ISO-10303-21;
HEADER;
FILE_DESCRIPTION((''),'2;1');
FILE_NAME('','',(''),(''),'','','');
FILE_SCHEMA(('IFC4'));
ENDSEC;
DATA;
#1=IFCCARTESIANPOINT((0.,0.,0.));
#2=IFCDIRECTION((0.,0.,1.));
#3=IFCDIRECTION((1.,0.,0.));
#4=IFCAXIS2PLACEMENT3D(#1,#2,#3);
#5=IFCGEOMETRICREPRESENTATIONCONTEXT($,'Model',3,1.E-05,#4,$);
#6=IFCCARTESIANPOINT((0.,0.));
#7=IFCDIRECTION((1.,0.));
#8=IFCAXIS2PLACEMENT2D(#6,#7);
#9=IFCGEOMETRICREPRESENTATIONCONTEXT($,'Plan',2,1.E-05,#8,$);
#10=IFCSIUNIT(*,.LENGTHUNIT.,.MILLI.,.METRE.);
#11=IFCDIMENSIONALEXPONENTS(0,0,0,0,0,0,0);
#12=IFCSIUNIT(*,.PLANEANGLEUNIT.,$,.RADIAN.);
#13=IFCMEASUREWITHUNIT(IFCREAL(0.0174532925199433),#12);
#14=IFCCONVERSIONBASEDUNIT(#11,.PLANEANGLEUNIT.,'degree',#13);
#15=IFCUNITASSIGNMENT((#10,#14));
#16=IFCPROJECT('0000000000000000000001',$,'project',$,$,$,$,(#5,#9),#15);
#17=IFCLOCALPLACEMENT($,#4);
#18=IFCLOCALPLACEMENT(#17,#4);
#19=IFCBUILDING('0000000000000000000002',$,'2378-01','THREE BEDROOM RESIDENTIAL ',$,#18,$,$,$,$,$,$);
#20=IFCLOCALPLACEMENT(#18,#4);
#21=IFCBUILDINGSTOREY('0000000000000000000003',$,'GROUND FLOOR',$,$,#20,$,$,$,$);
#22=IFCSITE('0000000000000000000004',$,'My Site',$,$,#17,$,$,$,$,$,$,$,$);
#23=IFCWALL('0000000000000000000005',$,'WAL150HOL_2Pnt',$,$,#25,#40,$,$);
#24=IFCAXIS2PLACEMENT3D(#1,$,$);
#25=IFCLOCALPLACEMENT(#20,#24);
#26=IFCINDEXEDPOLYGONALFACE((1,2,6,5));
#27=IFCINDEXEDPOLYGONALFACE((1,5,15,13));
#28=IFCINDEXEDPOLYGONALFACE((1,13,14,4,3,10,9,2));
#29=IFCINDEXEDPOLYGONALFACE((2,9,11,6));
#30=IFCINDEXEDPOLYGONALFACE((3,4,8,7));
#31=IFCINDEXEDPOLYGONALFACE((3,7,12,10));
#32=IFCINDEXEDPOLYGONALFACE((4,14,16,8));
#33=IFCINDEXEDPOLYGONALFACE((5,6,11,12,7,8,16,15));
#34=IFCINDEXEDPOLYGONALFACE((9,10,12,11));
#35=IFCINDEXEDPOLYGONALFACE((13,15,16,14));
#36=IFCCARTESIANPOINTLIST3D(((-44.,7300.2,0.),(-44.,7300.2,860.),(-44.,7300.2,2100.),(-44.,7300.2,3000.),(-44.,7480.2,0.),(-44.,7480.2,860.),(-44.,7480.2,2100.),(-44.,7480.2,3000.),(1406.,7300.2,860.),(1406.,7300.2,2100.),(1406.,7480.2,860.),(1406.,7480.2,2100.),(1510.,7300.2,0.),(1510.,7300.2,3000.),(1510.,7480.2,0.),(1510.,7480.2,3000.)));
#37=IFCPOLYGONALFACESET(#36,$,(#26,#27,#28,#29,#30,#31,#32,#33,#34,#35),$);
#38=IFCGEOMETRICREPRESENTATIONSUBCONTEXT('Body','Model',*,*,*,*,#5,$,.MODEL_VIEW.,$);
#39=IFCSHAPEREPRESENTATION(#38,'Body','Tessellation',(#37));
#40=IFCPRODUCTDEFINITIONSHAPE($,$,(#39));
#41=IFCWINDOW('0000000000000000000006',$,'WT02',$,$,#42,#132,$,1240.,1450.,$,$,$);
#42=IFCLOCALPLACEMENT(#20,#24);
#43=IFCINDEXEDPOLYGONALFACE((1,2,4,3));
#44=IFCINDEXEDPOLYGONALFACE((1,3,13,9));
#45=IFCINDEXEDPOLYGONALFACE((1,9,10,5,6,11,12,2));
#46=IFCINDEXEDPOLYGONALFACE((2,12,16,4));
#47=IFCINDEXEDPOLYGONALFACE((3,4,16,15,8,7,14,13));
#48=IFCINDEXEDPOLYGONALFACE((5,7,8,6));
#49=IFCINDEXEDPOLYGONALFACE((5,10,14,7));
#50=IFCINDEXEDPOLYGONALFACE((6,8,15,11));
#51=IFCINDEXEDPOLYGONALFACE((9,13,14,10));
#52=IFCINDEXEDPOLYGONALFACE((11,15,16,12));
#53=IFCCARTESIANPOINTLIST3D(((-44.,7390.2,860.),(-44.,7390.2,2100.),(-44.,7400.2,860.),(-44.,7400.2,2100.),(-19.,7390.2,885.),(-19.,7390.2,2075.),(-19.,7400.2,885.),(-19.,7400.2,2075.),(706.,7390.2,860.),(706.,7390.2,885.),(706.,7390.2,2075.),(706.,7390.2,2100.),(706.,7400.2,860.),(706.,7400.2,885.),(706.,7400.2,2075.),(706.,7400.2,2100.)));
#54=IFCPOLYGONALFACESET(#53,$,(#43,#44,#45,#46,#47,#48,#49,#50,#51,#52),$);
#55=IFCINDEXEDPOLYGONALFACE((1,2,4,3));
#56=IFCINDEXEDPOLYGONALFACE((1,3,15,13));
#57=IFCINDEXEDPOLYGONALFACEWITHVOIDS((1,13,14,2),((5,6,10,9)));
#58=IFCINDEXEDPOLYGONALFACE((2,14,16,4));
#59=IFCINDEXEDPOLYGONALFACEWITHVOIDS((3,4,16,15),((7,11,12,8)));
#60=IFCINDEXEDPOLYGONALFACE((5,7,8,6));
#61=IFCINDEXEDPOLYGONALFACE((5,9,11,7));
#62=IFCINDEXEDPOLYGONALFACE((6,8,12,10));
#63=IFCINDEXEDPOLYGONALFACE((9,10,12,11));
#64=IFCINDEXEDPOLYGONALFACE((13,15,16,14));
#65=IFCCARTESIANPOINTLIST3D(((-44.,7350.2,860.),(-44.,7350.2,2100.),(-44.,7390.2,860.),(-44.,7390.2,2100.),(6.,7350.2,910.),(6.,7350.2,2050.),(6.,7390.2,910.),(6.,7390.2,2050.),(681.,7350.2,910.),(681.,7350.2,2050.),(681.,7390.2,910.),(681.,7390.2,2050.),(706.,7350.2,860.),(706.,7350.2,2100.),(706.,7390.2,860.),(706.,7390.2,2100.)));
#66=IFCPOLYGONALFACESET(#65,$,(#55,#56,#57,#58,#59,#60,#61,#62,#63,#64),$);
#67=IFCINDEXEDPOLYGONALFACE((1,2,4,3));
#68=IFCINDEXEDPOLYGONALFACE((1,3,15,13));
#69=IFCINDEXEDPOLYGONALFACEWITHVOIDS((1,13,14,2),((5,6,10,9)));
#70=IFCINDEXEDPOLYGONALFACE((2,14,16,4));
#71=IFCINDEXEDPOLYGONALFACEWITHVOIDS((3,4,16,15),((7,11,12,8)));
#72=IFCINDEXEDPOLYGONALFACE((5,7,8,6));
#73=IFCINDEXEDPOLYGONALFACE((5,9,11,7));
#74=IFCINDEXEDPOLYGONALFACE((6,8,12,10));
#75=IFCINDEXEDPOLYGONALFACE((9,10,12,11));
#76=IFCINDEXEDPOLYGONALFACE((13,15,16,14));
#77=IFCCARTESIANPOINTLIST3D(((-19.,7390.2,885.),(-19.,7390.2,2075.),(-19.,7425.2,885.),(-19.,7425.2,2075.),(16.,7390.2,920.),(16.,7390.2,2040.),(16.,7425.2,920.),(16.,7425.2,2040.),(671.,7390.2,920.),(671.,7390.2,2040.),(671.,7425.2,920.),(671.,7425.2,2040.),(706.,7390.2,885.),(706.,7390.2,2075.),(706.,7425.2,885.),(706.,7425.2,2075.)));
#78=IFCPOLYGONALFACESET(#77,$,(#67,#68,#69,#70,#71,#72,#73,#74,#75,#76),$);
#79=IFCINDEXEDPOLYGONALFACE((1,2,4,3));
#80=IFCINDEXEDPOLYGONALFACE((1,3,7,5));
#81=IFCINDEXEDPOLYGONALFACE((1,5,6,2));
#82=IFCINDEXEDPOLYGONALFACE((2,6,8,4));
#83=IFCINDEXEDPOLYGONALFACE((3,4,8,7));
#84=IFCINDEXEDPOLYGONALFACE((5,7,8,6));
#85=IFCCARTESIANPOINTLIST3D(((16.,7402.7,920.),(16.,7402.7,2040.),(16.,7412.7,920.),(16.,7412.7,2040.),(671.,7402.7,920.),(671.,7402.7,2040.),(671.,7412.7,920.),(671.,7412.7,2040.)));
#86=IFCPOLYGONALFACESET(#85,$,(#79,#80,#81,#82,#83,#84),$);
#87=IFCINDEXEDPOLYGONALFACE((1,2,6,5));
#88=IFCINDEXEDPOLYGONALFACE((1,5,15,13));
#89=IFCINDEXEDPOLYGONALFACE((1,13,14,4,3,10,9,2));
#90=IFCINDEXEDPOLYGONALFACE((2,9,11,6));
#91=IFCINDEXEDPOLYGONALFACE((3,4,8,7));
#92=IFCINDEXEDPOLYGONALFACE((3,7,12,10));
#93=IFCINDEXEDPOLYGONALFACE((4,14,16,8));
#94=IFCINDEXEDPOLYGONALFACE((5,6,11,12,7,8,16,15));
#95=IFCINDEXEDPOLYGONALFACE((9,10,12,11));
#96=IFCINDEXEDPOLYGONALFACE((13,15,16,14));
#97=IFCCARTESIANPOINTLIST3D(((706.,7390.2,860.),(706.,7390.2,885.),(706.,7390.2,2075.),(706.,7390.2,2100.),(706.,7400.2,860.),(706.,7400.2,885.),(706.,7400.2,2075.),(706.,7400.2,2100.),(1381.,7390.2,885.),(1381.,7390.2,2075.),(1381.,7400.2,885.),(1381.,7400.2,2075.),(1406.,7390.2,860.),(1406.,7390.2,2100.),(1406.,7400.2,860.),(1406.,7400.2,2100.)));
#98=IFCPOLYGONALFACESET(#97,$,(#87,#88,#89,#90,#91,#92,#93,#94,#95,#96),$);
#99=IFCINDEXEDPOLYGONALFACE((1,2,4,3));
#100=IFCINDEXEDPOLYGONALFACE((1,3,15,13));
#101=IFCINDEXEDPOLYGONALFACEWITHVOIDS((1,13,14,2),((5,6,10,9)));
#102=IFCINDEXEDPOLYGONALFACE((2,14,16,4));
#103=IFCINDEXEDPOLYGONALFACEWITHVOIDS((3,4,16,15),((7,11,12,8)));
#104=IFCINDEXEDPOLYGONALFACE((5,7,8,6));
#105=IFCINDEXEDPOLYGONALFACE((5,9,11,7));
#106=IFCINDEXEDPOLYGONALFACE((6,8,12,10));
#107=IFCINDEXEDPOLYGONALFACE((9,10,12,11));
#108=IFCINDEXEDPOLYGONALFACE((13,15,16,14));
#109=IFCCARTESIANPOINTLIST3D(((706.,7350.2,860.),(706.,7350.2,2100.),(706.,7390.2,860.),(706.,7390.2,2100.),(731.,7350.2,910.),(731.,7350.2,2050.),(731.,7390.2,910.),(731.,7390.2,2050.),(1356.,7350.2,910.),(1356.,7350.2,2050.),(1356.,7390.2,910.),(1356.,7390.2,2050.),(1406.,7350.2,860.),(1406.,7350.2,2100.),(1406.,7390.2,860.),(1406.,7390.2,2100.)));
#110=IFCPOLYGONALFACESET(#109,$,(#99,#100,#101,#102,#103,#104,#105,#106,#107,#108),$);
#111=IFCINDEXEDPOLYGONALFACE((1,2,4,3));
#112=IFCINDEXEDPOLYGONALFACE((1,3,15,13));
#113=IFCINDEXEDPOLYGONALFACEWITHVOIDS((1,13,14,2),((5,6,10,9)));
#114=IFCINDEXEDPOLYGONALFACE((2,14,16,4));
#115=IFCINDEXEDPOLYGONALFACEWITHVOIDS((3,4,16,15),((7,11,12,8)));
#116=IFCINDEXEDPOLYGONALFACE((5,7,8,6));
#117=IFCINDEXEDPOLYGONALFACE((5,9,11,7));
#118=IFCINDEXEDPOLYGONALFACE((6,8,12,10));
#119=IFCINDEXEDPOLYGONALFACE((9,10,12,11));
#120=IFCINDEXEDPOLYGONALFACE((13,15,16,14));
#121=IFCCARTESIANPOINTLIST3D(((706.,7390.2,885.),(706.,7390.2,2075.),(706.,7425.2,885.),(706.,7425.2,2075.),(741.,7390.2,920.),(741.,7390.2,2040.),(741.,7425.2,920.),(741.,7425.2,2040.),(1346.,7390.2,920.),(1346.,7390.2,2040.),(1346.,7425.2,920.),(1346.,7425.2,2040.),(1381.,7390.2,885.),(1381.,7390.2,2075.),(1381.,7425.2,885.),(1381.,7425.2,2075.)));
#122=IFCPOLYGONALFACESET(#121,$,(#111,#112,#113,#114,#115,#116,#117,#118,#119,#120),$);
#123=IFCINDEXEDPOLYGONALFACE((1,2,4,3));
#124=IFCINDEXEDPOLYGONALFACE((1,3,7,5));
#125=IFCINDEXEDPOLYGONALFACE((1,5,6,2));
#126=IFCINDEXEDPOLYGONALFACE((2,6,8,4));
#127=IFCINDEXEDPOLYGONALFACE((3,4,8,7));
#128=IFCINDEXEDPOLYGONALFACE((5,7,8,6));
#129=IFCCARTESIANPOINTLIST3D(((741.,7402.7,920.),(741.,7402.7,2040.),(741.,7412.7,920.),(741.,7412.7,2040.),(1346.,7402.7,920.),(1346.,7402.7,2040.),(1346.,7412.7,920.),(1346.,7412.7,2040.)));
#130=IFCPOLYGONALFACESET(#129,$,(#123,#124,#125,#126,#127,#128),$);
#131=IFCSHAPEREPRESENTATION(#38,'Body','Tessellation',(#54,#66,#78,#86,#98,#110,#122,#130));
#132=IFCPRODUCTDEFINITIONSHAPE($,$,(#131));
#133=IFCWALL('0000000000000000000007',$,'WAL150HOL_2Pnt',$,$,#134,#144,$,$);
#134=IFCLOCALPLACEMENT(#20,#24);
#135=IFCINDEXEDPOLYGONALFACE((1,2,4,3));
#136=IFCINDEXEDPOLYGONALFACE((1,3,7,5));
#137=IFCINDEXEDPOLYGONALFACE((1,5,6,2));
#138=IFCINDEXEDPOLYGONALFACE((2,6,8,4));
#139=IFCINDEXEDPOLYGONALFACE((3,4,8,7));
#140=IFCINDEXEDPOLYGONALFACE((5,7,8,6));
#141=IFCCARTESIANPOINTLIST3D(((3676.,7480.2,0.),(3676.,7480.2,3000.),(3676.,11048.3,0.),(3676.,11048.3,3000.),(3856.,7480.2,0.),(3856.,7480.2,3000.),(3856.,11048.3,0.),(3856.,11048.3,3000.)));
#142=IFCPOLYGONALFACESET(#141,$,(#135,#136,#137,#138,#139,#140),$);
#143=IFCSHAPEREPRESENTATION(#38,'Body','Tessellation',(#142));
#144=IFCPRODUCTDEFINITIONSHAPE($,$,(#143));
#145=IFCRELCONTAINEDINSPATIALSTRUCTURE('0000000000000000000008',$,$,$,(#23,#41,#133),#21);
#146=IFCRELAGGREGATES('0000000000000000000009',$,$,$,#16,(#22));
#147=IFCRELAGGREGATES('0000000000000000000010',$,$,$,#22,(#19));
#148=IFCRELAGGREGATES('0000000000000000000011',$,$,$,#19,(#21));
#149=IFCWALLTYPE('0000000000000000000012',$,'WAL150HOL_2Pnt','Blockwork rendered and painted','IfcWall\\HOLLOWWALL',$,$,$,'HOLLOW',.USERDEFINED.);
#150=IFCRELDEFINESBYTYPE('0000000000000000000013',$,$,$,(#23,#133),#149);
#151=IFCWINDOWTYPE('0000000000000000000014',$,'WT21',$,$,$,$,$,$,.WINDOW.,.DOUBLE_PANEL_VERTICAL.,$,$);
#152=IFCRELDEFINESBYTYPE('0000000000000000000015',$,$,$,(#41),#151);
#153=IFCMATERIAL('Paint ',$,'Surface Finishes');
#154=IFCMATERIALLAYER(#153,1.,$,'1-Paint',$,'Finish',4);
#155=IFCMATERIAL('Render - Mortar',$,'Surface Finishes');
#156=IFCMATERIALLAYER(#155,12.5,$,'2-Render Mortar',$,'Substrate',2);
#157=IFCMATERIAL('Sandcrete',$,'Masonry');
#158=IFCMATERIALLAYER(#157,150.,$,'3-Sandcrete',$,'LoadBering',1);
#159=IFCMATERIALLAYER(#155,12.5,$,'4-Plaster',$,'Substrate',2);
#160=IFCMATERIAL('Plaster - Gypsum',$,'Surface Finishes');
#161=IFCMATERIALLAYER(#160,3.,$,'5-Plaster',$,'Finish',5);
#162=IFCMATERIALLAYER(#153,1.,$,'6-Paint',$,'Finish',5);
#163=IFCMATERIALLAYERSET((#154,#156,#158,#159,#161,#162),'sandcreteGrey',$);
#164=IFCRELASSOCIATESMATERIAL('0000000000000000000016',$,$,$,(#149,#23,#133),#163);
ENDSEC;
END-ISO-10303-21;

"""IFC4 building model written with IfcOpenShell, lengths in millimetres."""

from ifc_helpers import new_model, entity, si_unit, converted_unit, frame, origin_with_axes, origin_2d_with_axis, place, context, subcontext, project, spatial, line, indexed_curve, outline, extrude, shape, source, transform, mapped, material, layer, layer_set, layer_usage, type_object, type_shapes, element, fill, save


model = new_model("IFC4")

# Units and contexts
model_context = context("Model", 3, precision=1e-05, world=origin_with_axes())
plan_context = context("Plan", 2, precision=1e-05, world=origin_2d_with_axis())
body_context_1 = subcontext(model_context, "Body", "Model", "MODEL_VIEW")
body_context_2 = subcontext(plan_context, "Body", "Plan", "PLAN_VIEW")
ifc_project = project(units=[si_unit("LENGTHUNIT", "METRE", prefix="MILLI"), converted_unit("PLANEANGLEUNIT", "degree", entity("IfcReal", 0.0174532925199433), si_unit("PLANEANGLEUNIT", "RADIAN"), dimensions=[0, 0, 0, 0, 0, 0, 0])], contexts=[model_context, plan_context])

# Site, building, storey
site_placement = place(None, origin_with_axes())
site = spatial("IfcSite", under=ifc_project, at=site_placement, Name="My Site")
building_placement = place(site_placement, origin_with_axes())
building = spatial("IfcBuilding", under=site, at=building_placement, Name="2378-01", Description="THREE BEDROOM RESIDENTIAL ")
storey_placement = place(building_placement, origin_with_axes())
storey = spatial("IfcBuildingStorey", under=building, at=storey_placement, Name="GROUND FLOOR")

# Wall, opening, window
ifc_material_1 = material(Name="Paint ", Category="Surface Finishes")
ifc_layer_1 = layer(ifc_material_1, 1.0, Name="1-Paint", Category="Finish", Priority=4)
ifc_material_2 = material(Name="Render - Mortar", Category="Surface Finishes")
ifc_layer_2 = layer(ifc_material_2, 12.5, Name="2-Render Mortar", Category="Substrate", Priority=2)
ifc_material_3 = material(Name="Sandcrete", Category="Masonry")
ifc_layer_3 = layer(ifc_material_3, 150.0, Name="3-Sandcrete", Category="LoadBering", Priority=1)
ifc_layer_4 = layer(ifc_material_2, 12.5, Name="4-Plaster", Category="Substrate", Priority=2)
ifc_material_4 = material(Name="Plaster - Gypsum", Category="Surface Finishes")
ifc_layer_5 = layer(ifc_material_4, 3.0, Name="5-Plaster", Category="Finish", Priority=5)
ifc_layer_6 = layer(ifc_material_1, 1.0, Name="6-Paint", Category="Finish", Priority=5)
ifc_layer_set_1 = layer_set([ifc_layer_1, ifc_layer_2, ifc_layer_3, ifc_layer_4, ifc_layer_5, ifc_layer_6], Name="sandcreteGrey")
ifc_layer_usage_1 = layer_usage(ifc_layer_set_1, "AXIS2", "POSITIVE", 0.0)
wall_type_1 = type_object("IfcWallType", Name="WAL150HOL_2Pnt", Description="Blockwork rendered and painted", ApplicableOccurrence="IfcWall\\HOLLOWWALL", ElementType="HOLLOW", PredefinedType="USERDEFINED", material=ifc_layer_set_1)
wall_1_placement = place(storey_placement, frame((-44.0, 7300.2, 0.0), z_axis=(0.0, 0.0, 1.0), x_axis=(1.0, 0.0, 0.0)))
wall_1 = element("IfcWall", 1, at=wall_1_placement, inside=storey, type_object=wall_type_1, material=ifc_layer_usage_1, Name="WAL150HOL_2Pnt", context=body_context_1, shape_type="SweptSolid", body=[
    extrude(outline(indexed_curve([(0.0, 0.0), (0.0, 180.0), (1554.0, 180.0), (1554.0, 0.0), (0.0, 0.0)], self_intersect=False)), origin_with_axes(), (0.0, 0.0, 1.0), 3000.0),
])
shared_shape_1 = source(origin_with_axes(), body_context_1, "Body", "SweptSolid", [
    extrude(outline(indexed_curve([(0.0, 0.0), (1450.0, 0.0), (1450.0, 1240.0), (0.0, 1240.0)], segments=[line(1, 2, 3, 4, 1)])), frame((0.0, -100.0, 0.0), z_axis=(0.0, -1.0, 0.0), x_axis=(1.0, 0.0, 0.0)), (0.0, 0.0, -1.0), 388.0),
])
opening_1_placement = place(wall_1_placement, frame((0.0, 0.0, 860.0), z_axis=(0.0, 0.0, 1.0), x_axis=(1.0, 0.0, 0.0)))
opening_1 = element("IfcOpeningElement", 2, at=opening_1_placement, cuts=wall_1, PredefinedType="OPENING", context=body_context_1, shape_type="MappedRepresentation", body=[
    mapped(shared_shape_1, transform((0.0, 0.0, 0.0), x_axis=(1.0, 0.0, 0.0), y_axis=(0.0, 1.0, 0.0), z_axis=(0.0, 0.0, 1.0), scale=1.0)),
])
window_type_1 = type_object("IfcWindowType", Name="WT21", PartitioningType="DOUBLE_PANEL_VERTICAL", PredefinedType="WINDOW")
shared_shape_2 = source(origin_with_axes(), body_context_1, "Body", "SweptSolid", [
    extrude(outline(indexed_curve([(750.0, 0.0), (0.0, 0.0), (0.0, 1240.0), (750.0, 1240.0), (750.0, 1215.0), (25.0, 1215.0), (25.0, 25.0), (750.0, 25.0)], segments=[line(1, 2, 3, 4, 5, 6, 7, 8, 1)])), frame((0.0, 90.0, 0.0), z_axis=(0.0, -1.0, 0.0), x_axis=(1.0, 0.0, 0.0)), (0.0, 0.0, -1.0), 10.0),
    extrude(outline(indexed_curve([(0.0, 0.0), (750.0, 0.0), (750.0, 1240.0), (0.0, 1240.0)], segments=[line(1, 2, 3, 4, 1)]), holes=[indexed_curve([(50.0, 50.0), (725.0, 50.0), (725.0, 1190.0), (50.0, 1190.0)], segments=[line(1, 2, 3, 4, 1)])]), frame((0.0, 50.0, 0.0), z_axis=(0.0, -1.0, 0.0), x_axis=(1.0, 0.0, 0.0)), (0.0, 0.0, -1.0), 40.0),
    extrude(outline(indexed_curve([(0.0, 0.0), (725.0, 0.0), (725.0, 1190.0), (0.0, 1190.0)], segments=[line(1, 2, 3, 4, 1)]), holes=[indexed_curve([(35.0, 35.0), (690.0, 35.0), (690.0, 1155.0), (35.0, 1155.0)], segments=[line(1, 2, 3, 4, 1)])]), frame((25.0, 90.0, 25.0), z_axis=(0.0, -1.0, 0.0), x_axis=(1.0, 0.0, 0.0)), (0.0, 0.0, -1.0), 35.0),
    extrude(outline(indexed_curve([(35.0, 35.0), (690.0, 35.0), (690.0, 1155.0), (35.0, 1155.0)], segments=[line(1, 2, 3, 4, 1)])), frame((25.0, 102.5, 25.0), z_axis=(0.0, -1.0, 0.0), x_axis=(1.0, 0.0, 0.0)), (0.0, 0.0, -1.0), 10.0),
    extrude(outline(indexed_curve([(0.0, 1240.0), (700.0, 1240.0), (700.0, 0.0), (0.0, 0.0), (0.0, 25.0), (675.0, 25.0), (675.0, 1215.0), (0.0, 1215.0)], segments=[line(1, 2, 3, 4, 5, 6, 7, 8, 1)])), frame((750.0, 90.0, 0.0), z_axis=(0.0, -1.0, 0.0), x_axis=(1.0, 0.0, 0.0)), (0.0, 0.0, -1.0), 10.0),
    extrude(outline(indexed_curve([(0.0, 0.0), (700.0, 0.0), (700.0, 1240.0), (0.0, 1240.0)], segments=[line(1, 2, 3, 4, 1)]), holes=[indexed_curve([(25.0, 50.0), (650.0, 50.0), (650.0, 1190.0), (25.0, 1190.0)], segments=[line(1, 2, 3, 4, 1)])]), frame((750.0, 50.0, 0.0), z_axis=(0.0, -1.0, 0.0), x_axis=(1.0, 0.0, 0.0)), (0.0, 0.0, -1.0), 40.0),
    extrude(outline(indexed_curve([(0.0, 0.0), (675.0, 0.0), (675.0, 1190.0), (0.0, 1190.0)], segments=[line(1, 2, 3, 4, 1)]), holes=[indexed_curve([(35.0, 35.0), (640.0, 35.0), (640.0, 1155.0), (35.0, 1155.0)], segments=[line(1, 2, 3, 4, 1)])]), frame((750.0, 90.0, 25.0), z_axis=(0.0, -1.0, 0.0), x_axis=(1.0, 0.0, 0.0)), (0.0, 0.0, -1.0), 35.0),
    extrude(outline(indexed_curve([(35.0, 35.0), (640.0, 35.0), (640.0, 1155.0), (35.0, 1155.0)], segments=[line(1, 2, 3, 4, 1)])), frame((750.0, 102.5, 25.0), z_axis=(0.0, -1.0, 0.0), x_axis=(1.0, 0.0, 0.0)), (0.0, 0.0, -1.0), 10.0),
])
shared_shape_3 = source(origin_with_axes(), body_context_2, "Body", "Curve2D", [
    entity("IfcIndexedPolyCurve", entity("IfcCartesianPointList2D", [[50.0, 50.0], [725.0, 50.0]])),
    entity("IfcIndexedPolyCurve", entity("IfcCartesianPointList2D", [[0.0, 100.0], [25.0, 100.0], [25.0, 90.0], [50.0, 90.0], [50.0, 50.0], [0.0, 50.0]]), [entity("IfcLineIndex", [1, 2, 3, 4, 5, 6, 1])]),
    entity("IfcIndexedPolyCurve", entity("IfcCartesianPointList2D", [[750.0, 100.0], [750.0, 100.0], [750.0, 90.0], [725.0, 90.0], [725.0, 50.0], [750.0, 50.0]])),
    entity("IfcIndexedPolyCurve", entity("IfcCartesianPointList2D", [[25.0, 90.0], [60.0, 90.0], [60.0, 125.0], [25.0, 125.0]]), [entity("IfcLineIndex", [1, 2, 3, 4, 1])]),
    entity("IfcIndexedPolyCurve", entity("IfcCartesianPointList2D", [[750.0, 90.0], [715.0, 90.0], [715.0, 125.0], [750.0, 125.0]]), [entity("IfcLineIndex", [1, 2, 3, 4, 1])]),
    entity("IfcIndexedPolyCurve", entity("IfcCartesianPointList2D", [[60.0, 90.0], [715.0, 90.0]])),
    entity("IfcIndexedPolyCurve", entity("IfcCartesianPointList2D", [[60.0, 125.0], [715.0, 125.0]])),
    entity("IfcIndexedPolyCurve", entity("IfcCartesianPointList2D", [[60.0, 107.5], [715.0, 107.5]])),
    entity("IfcIndexedPolyCurve", entity("IfcCartesianPointList2D", [[775.0, 50.0], [1400.0, 50.0]])),
    entity("IfcIndexedPolyCurve", entity("IfcCartesianPointList2D", [[750.0, 100.0], [750.0, 100.0], [750.0, 90.0], [775.0, 90.0], [775.0, 50.0], [750.0, 50.0]])),
    entity("IfcIndexedPolyCurve", entity("IfcCartesianPointList2D", [[1450.0, 100.0], [1425.0, 100.0], [1425.0, 90.0], [1400.0, 90.0], [1400.0, 50.0], [1450.0, 50.0]]), [entity("IfcLineIndex", [1, 2, 3, 4, 5, 6, 1])]),
    entity("IfcIndexedPolyCurve", entity("IfcCartesianPointList2D", [[750.0, 90.0], [785.0, 90.0], [785.0, 125.0], [750.0, 125.0]]), [entity("IfcLineIndex", [1, 2, 3, 4, 1])]),
    entity("IfcIndexedPolyCurve", entity("IfcCartesianPointList2D", [[1425.0, 90.0], [1390.0, 90.0], [1390.0, 125.0], [1425.0, 125.0]]), [entity("IfcLineIndex", [1, 2, 3, 4, 1])]),
    entity("IfcIndexedPolyCurve", entity("IfcCartesianPointList2D", [[785.0, 90.0], [1390.0, 90.0]])),
    entity("IfcIndexedPolyCurve", entity("IfcCartesianPointList2D", [[785.0, 125.0], [1390.0, 125.0]])),
    entity("IfcIndexedPolyCurve", entity("IfcCartesianPointList2D", [[785.0, 107.5], [1390.0, 107.5]])),
])
type_shapes(window_type_1, [shared_shape_2, shared_shape_3])
window_1_placement = place(opening_1_placement, origin_with_axes())
window_1 = element("IfcWindow", 3, at=window_1_placement, inside=storey, type_object=window_type_1, Name="WT02", OverallHeight=1240.0, OverallWidth=1450.0, shapes=[
    shape(body_context_1, "Body", "MappedRepresentation", [mapped(shared_shape_2, transform((0.0, 0.0, 0.0), x_axis=(1.0, 0.0, 0.0), y_axis=(0.0, 1.0, 0.0), z_axis=(0.0, 0.0, 1.0), scale=1.0))]),
    shape(body_context_2, "Body", "MappedRepresentation", [mapped(shared_shape_3, transform((0.0, 0.0, 0.0), x_axis=(1.0, 0.0, 0.0), y_axis=(0.0, 1.0, 0.0), z_axis=(0.0, 0.0, 1.0), scale=1.0))]),
])
fill(opening_1, window_1)

# Wall
ifc_layer_usage_2 = layer_usage(ifc_layer_set_1, "AXIS2", "POSITIVE", 0.0)
wall_2_placement = place(storey_placement, frame((3856.0, 7480.2, 0.0), z_axis=(0.0, 0.0, 1.0), x_axis=(0.0, 1.0, 0.0)))
element("IfcWall", 4, at=wall_2_placement, inside=storey, type_object=wall_type_1, material=ifc_layer_usage_2, Name="WAL150HOL_2Pnt", context=body_context_1, shape_type="SweptSolid", body=[
    extrude(outline(indexed_curve([(0.0, 0.0), (0.0, 180.0), (3568.1, 180.0), (3568.1, 0.0), (0.0, 0.0)], self_intersect=False)), origin_with_axes(), (0.0, 0.0, 1.0), 3000.0),
])

save(model, "model.ifc")
